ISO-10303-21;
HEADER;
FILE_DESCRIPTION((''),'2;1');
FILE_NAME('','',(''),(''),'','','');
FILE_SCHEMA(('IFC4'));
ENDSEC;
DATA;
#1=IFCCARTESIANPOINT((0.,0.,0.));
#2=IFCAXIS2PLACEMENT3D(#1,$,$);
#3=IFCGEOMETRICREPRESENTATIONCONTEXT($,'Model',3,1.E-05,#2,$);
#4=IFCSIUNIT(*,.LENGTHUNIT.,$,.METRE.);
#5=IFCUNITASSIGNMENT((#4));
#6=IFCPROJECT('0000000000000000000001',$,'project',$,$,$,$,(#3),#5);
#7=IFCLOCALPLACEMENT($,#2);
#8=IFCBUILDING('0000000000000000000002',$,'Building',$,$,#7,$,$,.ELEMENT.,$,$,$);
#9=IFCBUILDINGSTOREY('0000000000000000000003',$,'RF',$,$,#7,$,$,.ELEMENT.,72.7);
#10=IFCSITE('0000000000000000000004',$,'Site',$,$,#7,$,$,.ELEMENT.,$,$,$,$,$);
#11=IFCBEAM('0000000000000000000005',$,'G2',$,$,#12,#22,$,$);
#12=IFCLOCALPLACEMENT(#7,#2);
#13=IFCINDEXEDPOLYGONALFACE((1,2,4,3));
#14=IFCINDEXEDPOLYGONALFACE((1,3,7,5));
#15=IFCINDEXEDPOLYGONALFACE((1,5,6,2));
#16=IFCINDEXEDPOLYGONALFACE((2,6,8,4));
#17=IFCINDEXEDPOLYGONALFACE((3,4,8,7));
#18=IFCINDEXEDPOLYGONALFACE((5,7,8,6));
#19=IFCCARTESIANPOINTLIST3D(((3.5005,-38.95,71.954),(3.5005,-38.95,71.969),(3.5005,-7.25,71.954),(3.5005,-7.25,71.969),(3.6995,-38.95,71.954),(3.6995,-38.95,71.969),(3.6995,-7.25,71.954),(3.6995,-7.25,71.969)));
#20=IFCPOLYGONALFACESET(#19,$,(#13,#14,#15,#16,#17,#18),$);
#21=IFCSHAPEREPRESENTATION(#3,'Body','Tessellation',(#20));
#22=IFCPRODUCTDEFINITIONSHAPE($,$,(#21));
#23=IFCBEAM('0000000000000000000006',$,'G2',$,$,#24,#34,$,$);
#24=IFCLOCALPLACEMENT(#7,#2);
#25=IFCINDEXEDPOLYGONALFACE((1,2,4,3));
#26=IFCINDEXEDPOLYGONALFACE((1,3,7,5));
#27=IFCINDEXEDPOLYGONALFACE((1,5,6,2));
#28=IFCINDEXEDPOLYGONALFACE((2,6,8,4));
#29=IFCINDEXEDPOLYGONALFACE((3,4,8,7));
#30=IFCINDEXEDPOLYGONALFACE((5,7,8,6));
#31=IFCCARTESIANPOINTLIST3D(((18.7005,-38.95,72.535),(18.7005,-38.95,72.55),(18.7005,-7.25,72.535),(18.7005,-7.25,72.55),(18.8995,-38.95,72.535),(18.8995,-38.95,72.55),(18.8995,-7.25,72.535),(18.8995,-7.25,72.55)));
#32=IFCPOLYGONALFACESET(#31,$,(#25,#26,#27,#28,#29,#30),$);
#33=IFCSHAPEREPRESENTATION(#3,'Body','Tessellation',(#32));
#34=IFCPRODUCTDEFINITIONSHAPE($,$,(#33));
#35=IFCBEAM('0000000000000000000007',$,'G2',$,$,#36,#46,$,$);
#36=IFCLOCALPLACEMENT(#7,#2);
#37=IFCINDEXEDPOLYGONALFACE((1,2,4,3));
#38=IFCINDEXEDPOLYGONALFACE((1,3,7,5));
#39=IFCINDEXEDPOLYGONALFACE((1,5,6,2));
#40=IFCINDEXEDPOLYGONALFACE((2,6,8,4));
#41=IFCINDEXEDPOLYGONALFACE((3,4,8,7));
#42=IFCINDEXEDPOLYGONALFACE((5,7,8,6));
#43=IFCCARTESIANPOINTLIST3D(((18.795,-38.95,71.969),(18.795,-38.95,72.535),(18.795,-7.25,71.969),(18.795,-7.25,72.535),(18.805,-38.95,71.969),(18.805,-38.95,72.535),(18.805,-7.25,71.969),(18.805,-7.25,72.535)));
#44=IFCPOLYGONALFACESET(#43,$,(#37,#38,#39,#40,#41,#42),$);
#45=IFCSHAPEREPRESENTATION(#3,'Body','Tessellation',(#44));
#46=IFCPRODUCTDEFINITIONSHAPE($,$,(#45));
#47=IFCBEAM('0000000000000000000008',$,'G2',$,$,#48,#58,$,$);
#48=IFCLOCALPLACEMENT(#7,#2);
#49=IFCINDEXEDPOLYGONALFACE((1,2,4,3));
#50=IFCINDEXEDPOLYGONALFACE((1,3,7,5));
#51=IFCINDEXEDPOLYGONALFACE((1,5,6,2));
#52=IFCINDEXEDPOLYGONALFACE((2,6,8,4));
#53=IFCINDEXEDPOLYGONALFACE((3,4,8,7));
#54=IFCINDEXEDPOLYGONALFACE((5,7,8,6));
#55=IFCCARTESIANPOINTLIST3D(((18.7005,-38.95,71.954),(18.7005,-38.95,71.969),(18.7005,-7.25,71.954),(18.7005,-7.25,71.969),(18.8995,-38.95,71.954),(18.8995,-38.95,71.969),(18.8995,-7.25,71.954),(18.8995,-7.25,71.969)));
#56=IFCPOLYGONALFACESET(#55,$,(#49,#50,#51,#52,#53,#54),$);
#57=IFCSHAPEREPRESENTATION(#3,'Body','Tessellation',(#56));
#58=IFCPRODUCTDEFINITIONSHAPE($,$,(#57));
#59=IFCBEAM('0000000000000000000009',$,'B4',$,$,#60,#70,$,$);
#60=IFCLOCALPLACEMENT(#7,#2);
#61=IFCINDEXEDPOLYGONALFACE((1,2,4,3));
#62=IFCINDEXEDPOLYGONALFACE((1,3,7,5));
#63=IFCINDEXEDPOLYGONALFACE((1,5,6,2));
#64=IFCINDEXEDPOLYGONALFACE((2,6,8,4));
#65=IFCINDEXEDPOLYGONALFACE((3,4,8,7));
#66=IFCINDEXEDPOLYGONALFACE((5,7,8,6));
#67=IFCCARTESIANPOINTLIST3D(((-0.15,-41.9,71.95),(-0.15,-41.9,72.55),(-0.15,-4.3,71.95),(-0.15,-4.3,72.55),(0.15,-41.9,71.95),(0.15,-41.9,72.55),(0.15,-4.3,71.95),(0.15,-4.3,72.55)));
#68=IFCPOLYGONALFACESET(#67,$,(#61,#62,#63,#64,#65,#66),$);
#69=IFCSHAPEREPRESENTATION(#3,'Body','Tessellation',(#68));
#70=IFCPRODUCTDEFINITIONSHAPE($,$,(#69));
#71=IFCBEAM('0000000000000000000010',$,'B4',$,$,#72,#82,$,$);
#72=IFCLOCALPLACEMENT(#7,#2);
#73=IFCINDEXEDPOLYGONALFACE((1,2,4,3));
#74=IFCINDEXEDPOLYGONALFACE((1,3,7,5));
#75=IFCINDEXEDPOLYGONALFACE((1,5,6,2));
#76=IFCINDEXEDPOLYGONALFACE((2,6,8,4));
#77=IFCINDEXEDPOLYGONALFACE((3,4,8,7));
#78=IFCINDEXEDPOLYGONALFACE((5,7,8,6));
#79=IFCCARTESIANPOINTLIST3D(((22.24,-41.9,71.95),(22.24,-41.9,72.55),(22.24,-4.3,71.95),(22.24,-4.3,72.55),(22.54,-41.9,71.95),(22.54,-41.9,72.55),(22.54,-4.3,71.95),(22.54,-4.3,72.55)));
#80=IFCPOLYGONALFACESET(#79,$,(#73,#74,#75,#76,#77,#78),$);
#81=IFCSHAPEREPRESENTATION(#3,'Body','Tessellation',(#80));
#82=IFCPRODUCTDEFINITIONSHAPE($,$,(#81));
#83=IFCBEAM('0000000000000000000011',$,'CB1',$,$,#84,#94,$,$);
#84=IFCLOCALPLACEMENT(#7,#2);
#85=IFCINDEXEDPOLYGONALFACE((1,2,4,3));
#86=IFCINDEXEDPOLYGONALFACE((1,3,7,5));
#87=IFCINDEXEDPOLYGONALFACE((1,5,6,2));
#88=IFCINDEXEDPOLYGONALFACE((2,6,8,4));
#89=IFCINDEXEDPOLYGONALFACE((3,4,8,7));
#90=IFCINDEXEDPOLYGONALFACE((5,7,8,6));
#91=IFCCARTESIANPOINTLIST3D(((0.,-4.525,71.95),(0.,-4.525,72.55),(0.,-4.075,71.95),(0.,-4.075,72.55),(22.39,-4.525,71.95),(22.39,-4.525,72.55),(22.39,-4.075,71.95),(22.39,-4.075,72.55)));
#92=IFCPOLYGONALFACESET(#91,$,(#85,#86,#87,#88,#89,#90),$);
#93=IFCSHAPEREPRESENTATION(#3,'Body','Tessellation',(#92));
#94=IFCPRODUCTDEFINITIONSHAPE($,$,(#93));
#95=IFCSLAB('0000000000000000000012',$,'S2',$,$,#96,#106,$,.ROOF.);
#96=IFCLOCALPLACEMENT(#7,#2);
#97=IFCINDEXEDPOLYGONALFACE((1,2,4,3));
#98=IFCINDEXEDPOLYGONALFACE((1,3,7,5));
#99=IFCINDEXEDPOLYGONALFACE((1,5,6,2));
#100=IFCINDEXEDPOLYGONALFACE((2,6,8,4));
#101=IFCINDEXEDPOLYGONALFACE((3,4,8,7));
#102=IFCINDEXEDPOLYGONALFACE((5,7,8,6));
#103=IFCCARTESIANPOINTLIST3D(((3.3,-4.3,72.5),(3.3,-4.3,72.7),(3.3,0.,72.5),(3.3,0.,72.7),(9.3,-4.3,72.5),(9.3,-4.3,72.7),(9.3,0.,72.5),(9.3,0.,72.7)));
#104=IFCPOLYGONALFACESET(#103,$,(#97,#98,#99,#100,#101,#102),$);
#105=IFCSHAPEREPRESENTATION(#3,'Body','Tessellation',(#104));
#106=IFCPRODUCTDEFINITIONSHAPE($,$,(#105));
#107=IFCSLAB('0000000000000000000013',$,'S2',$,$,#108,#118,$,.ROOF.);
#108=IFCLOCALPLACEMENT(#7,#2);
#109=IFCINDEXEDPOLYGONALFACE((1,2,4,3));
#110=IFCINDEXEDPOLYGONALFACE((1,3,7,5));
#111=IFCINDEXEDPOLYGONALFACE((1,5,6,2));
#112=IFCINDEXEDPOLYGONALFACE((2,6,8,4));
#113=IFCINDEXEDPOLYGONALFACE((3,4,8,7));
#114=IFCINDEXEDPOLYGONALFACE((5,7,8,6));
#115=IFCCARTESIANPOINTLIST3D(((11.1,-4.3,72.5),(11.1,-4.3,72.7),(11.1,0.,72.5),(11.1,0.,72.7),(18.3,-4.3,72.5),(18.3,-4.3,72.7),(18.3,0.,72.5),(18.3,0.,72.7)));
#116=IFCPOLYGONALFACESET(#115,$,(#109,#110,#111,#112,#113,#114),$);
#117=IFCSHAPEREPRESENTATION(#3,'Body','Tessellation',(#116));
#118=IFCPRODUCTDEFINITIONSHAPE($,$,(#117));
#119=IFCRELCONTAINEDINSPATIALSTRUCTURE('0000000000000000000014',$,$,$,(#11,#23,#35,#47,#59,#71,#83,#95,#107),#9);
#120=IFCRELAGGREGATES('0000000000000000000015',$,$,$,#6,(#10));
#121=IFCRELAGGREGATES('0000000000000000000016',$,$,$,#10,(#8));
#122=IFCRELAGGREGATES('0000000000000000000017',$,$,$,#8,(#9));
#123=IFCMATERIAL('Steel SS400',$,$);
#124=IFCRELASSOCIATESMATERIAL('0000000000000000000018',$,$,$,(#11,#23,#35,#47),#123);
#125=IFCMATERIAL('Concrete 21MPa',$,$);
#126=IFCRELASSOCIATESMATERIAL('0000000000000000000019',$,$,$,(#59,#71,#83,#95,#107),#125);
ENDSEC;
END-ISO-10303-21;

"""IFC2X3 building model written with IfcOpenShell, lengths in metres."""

from ifc_helpers import new_model, si_unit, frame, origin, origin_2d, place, context, project, spatial, rectangle, extrude, material, element, save


model = new_model("IFC2X3")

# Units and contexts
model_context = context("Model", 3, precision=1e-05, world=origin())
ifc_project = project(units=[si_unit("LENGTHUNIT", "METRE")], contexts=[model_context])

# Site, building, storey
placement = place(None, origin())
site = spatial("IfcSite", under=ifc_project, at=placement, Name="Site", CompositionType="ELEMENT")
building = spatial("IfcBuilding", under=site, at=placement, Name="Building", CompositionType="ELEMENT")
storey = spatial("IfcBuildingStorey", under=building, at=placement, Name="RF", CompositionType="ELEMENT", Elevation=72.7)

# Beams
ifc_material_1 = material(Name="Steel SS400")
for number, where, name in (
    (1, (3.6, -23.1, 71.954), "G2"),
    (2, (18.8, -23.1, 72.535), "G2"),
):
    element("IfcBeam", number, at=place(None, frame(where)), inside=storey, material=ifc_material_1, Name=name, context=model_context, shape_type="SweptSolid", body=[
        extrude(rectangle(XDim=0.199, YDim=31.7, at=origin_2d()), origin(), (0.0, 0.0, 1.0), 0.015),
    ])
beam_1_placement = place(None, frame((18.8, -23.1, 71.969)))
element("IfcBeam", 3, at=beam_1_placement, inside=storey, material=ifc_material_1, Name="G2", context=model_context, shape_type="SweptSolid", body=[
    extrude(rectangle(XDim=0.01, YDim=31.7, at=origin_2d()), origin(), (0.0, 0.0, 1.0), 0.566),
])
beam_2_placement = place(None, frame((18.8, -23.1, 71.954)))
element("IfcBeam", 4, at=beam_2_placement, inside=storey, material=ifc_material_1, Name="G2", context=model_context, shape_type="SweptSolid", body=[
    extrude(rectangle(XDim=0.199, YDim=31.7, at=origin_2d()), origin(), (0.0, 0.0, 1.0), 0.015),
])
ifc_material_2 = material(Name="Concrete 21MPa")
for number, where, name in (
    (5, (0.0, -23.1, 71.95), "B4"),
    (6, (22.39, -23.1, 71.95), "B4"),
):
    element("IfcBeam", number, at=place(None, frame(where)), inside=storey, material=ifc_material_2, Name=name, context=model_context, shape_type="SweptSolid", body=[
        extrude(rectangle(XDim=0.3, YDim=37.6, at=origin_2d()), origin(), (0.0, 0.0, 1.0), 0.6),
    ])
beam_3_placement = place(None, frame((11.195, -4.3, 71.95)))
element("IfcBeam", 7, at=beam_3_placement, inside=storey, material=ifc_material_2, Name="CB1", context=model_context, shape_type="SweptSolid", body=[
    extrude(rectangle(XDim=22.39, YDim=0.45, at=origin_2d()), origin(), (0.0, 0.0, 1.0), 0.6),
])

# Slabs
slab_1_placement = place(None, frame((6.3, -2.15, 72.5)))
element("IfcSlab", 8, at=slab_1_placement, inside=storey, material=ifc_material_2, Name="S2", PredefinedType="ROOF", context=model_context, shape_type="SweptSolid", body=[
    extrude(rectangle(XDim=6.0, YDim=4.3, at=origin_2d()), origin(), (0.0, 0.0, 1.0), 0.2),
])
slab_2_placement = place(None, frame((14.7, -2.15, 72.5)))
element("IfcSlab", 9, at=slab_2_placement, inside=storey, material=ifc_material_2, Name="S2", PredefinedType="ROOF", context=model_context, shape_type="SweptSolid", body=[
    extrude(rectangle(XDim=7.2, YDim=4.3, at=origin_2d()), origin(), (0.0, 0.0, 1.0), 0.2),
])

save(model, "model.ifc")
